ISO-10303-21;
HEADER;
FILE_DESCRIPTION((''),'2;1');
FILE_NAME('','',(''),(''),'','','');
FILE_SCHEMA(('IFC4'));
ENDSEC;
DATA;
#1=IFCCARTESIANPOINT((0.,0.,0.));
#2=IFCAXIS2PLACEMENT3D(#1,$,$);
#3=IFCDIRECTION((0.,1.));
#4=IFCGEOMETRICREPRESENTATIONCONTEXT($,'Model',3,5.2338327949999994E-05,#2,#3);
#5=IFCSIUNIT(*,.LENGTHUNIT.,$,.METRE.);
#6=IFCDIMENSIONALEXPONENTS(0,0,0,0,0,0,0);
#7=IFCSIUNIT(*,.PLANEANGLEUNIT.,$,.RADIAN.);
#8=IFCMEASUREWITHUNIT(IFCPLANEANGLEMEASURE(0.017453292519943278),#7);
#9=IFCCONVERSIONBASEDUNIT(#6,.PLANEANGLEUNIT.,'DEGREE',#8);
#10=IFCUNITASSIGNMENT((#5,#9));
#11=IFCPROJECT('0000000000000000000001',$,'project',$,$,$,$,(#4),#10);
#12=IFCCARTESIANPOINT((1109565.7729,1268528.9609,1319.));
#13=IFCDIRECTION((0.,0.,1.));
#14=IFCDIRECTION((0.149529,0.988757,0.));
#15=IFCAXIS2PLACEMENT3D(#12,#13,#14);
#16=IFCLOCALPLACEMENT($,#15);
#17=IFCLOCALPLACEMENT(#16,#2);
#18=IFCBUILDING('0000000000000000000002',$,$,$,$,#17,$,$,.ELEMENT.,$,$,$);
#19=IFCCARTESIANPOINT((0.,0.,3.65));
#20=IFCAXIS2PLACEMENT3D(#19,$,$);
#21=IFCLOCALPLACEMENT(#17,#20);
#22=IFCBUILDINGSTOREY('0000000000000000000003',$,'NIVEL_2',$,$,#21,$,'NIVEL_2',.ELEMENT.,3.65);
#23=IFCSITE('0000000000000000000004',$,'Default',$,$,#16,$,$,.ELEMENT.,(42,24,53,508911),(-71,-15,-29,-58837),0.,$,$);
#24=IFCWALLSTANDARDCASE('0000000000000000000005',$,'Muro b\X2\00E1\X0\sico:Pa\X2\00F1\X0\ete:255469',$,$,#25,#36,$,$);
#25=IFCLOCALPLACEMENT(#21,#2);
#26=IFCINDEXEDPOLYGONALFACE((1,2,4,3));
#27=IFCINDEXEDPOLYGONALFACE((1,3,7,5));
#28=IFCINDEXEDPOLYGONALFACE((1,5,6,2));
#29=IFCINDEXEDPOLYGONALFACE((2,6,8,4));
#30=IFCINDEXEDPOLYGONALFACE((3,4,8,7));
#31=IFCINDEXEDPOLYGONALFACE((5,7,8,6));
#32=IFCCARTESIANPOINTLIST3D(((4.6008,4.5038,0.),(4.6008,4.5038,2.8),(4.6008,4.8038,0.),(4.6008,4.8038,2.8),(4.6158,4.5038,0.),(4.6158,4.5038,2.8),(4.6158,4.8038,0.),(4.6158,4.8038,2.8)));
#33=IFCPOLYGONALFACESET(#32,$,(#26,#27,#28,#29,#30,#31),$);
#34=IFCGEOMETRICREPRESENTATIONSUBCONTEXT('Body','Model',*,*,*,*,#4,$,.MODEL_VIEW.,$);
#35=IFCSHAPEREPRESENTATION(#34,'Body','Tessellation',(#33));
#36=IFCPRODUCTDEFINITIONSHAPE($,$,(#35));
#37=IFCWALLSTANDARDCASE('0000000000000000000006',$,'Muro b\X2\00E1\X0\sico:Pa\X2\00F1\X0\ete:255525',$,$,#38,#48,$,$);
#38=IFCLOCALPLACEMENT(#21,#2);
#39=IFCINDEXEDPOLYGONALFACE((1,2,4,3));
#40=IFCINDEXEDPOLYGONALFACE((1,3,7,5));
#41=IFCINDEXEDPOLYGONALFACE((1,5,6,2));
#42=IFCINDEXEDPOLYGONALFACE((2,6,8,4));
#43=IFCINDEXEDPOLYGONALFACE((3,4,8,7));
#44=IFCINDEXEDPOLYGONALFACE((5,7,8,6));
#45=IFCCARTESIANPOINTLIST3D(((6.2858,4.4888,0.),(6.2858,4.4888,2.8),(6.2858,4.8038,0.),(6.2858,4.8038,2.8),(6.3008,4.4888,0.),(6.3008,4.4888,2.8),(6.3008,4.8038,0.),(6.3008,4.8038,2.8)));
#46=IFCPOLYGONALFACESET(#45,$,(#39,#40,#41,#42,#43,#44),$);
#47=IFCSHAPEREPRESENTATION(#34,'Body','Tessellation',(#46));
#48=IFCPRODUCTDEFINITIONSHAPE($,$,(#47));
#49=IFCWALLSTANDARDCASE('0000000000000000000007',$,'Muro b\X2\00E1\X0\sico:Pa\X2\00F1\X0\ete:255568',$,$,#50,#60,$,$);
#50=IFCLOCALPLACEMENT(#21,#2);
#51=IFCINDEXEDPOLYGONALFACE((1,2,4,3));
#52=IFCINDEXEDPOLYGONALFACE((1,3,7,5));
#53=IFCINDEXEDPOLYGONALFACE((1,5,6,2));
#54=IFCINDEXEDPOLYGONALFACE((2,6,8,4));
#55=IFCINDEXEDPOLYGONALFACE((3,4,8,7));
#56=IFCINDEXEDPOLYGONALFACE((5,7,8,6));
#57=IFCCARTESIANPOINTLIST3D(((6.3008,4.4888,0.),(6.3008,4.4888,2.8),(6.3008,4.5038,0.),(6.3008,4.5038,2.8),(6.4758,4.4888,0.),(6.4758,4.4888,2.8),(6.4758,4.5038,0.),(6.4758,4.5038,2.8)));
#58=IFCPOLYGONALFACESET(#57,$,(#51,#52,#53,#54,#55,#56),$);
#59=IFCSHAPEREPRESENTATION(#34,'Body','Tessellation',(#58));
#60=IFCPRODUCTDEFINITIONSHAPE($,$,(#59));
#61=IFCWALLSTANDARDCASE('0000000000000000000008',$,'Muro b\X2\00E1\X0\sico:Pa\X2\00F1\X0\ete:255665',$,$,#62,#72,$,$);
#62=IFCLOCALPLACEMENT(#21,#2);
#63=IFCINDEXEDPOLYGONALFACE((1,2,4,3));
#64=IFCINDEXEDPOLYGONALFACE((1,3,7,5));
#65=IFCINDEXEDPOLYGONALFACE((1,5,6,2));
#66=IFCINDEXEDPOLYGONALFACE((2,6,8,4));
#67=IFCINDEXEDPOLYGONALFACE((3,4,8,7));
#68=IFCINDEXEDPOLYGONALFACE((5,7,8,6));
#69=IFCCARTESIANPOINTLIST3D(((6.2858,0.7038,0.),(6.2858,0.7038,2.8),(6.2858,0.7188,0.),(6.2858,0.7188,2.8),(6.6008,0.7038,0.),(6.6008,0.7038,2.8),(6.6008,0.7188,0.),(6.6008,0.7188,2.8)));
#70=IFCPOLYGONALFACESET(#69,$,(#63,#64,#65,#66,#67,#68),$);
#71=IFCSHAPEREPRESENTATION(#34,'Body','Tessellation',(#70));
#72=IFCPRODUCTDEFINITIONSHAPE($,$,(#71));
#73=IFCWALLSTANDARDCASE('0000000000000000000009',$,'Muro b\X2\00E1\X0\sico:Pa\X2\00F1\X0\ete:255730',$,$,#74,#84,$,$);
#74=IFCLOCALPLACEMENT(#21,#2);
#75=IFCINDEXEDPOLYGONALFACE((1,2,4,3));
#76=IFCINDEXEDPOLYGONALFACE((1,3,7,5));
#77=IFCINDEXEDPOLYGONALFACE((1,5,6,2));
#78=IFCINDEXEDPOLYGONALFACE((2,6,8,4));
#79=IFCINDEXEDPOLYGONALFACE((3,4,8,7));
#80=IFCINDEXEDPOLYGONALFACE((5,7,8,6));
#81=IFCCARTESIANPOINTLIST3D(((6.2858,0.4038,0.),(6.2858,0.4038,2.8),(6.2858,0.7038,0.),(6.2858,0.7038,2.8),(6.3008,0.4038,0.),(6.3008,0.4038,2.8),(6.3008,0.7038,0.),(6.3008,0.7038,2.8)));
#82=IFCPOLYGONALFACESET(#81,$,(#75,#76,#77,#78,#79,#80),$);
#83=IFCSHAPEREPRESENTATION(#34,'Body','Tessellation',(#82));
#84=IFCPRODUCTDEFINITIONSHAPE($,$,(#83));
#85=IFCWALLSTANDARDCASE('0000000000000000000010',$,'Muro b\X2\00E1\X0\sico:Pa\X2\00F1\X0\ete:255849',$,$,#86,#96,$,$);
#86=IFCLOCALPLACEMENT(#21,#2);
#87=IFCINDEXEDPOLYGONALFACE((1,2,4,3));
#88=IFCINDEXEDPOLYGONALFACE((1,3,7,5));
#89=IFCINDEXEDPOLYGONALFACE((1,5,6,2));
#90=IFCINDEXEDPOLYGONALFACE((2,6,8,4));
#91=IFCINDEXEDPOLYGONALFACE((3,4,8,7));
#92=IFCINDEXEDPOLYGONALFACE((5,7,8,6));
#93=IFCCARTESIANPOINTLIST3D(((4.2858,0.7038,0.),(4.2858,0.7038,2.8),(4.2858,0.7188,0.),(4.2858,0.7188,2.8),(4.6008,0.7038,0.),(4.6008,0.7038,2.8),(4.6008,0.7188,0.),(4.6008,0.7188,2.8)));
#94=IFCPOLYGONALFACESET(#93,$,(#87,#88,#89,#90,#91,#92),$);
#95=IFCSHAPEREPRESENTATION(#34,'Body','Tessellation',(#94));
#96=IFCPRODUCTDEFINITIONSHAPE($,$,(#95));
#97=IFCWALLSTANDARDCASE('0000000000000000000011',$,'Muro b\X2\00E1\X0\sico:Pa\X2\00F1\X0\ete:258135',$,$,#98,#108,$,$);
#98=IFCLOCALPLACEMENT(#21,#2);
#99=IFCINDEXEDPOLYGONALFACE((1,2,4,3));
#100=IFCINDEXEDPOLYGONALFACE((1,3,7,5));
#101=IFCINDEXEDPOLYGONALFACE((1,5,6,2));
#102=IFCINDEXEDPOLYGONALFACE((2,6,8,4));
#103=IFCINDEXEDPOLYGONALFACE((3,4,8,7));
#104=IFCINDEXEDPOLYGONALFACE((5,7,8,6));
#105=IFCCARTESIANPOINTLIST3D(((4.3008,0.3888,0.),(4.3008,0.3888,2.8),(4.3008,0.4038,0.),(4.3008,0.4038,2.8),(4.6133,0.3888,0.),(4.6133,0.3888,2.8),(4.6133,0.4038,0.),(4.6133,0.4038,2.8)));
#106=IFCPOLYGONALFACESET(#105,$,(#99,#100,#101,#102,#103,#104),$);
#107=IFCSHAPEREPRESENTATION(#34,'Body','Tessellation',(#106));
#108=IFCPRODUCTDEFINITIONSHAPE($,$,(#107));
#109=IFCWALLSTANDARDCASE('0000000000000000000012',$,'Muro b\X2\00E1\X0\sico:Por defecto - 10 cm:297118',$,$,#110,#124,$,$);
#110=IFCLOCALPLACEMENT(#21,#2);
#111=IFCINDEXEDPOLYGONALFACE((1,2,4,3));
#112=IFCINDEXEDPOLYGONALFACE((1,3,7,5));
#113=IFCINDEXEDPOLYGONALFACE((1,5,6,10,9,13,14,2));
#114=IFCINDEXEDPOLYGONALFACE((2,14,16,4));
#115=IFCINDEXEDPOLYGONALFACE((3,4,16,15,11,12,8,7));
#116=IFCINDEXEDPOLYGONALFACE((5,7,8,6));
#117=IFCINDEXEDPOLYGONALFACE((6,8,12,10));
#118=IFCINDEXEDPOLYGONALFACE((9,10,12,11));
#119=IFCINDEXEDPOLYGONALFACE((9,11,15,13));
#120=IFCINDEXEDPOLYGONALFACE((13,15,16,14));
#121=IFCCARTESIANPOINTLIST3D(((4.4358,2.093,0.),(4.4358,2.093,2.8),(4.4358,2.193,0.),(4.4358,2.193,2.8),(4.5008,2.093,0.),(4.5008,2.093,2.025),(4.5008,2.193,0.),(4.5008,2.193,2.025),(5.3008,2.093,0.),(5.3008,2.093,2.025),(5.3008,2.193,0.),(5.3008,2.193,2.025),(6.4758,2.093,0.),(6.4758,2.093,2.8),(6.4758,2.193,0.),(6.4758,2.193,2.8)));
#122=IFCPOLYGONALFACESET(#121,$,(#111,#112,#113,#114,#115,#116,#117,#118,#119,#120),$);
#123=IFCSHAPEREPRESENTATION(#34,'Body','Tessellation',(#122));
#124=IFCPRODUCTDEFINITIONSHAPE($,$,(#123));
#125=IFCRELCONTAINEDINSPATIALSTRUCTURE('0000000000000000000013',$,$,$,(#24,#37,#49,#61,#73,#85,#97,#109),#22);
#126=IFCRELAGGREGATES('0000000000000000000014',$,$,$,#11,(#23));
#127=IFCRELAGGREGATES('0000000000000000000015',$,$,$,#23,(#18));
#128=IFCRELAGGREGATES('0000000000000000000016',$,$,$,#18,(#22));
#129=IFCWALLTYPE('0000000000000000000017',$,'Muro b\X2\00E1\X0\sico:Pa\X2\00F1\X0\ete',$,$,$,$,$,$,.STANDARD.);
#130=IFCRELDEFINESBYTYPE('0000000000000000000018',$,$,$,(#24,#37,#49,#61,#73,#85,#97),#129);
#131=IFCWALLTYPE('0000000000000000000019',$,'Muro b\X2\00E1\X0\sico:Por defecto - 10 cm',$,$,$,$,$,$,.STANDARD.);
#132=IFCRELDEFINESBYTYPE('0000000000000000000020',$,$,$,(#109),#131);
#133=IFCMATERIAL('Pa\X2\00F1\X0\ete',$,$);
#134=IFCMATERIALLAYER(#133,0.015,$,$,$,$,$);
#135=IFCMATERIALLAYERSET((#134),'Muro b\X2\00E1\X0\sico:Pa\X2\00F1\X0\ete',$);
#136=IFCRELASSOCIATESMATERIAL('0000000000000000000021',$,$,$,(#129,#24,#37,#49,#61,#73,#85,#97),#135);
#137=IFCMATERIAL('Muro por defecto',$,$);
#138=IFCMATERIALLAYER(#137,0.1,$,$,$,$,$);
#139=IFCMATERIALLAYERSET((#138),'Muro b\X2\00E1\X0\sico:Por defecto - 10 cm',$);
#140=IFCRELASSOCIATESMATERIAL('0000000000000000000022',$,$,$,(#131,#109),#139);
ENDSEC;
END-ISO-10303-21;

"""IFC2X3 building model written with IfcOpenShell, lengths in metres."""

from ifc_helpers import new_model, entity, si_unit, converted_unit, direction, frame, frame_2d, origin, place, context, subcontext, project, spatial, rectangle, extrude, material, layer, layer_set, layer_usage, type_object, element, save


model = new_model("IFC2X3")

# Units and contexts
model_context = context("Model", 3, precision=5.2338327949999994e-05, world=origin(), true_north=direction((0.0, 1.0)))
body_context = subcontext(model_context, "Body", "Model", "MODEL_VIEW")
ifc_project = project(units=[si_unit("LENGTHUNIT", "METRE"), converted_unit("PLANEANGLEUNIT", "DEGREE", entity("IfcPlaneAngleMeasure", 0.017453292519943278), si_unit("PLANEANGLEUNIT", "RADIAN"), dimensions=[0, 0, 0, 0, 0, 0, 0])], contexts=[model_context])

# Site, building, storey
site_placement = place(None, frame((1109565.7729, 1268528.9609, 1319.0), z_axis=(0.0, 0.0, 1.0), x_axis=(0.149529, 0.988757, 0.0)))
site = spatial("IfcSite", under=ifc_project, at=site_placement, Name="Default", CompositionType="ELEMENT", RefLatitude=(42, 24, 53, 508911), RefLongitude=(-71, -15, -29, -58837), RefElevation=0.0)
building_placement = place(site_placement, origin())
building = spatial("IfcBuilding", under=site, at=building_placement, CompositionType="ELEMENT")
storey_placement = place(building_placement, frame((0.0, 0.0, 3.65)))
storey = spatial("IfcBuildingStorey", under=building, at=storey_placement, Name="NIVEL_2", LongName="NIVEL_2", CompositionType="ELEMENT", Elevation=3.65)

# Shared definitions
ifc_material_1 = material(Name="Pañete")

# Walls
ifc_layer_1 = layer(ifc_material_1, 0.015)
ifc_layer_set_1 = layer_set([ifc_layer_1], Name="Muro básico:Pañete")
wall_type_1 = type_object("IfcWallType", Name="Muro básico:Pañete", PredefinedType="STANDARD", material=ifc_layer_set_1)
ifc_layer_usage_1 = layer_usage(ifc_layer_set_1, "AXIS2", "POSITIVE", -0.0075)
wall_1_placement = place(storey_placement, frame((4.6083, 4.5038, 0.0), z_axis=(0.0, 0.0, 1.0), x_axis=(0.0, 1.0, 0.0)))
element("IfcWallStandardCase", 1, at=wall_1_placement, inside=storey, type_object=wall_type_1, material=ifc_layer_usage_1, Name="Muro básico:Pañete:255469", context=body_context, shape_type="SweptSolid", body=[
    extrude(rectangle(XDim=0.3, YDim=0.015, at=frame_2d((0.15, 0.0), x_axis=(-1.0, 0.0))), origin(), (0.0, 0.0, 1.0), 2.8),
])
ifc_layer_usage_2 = layer_usage(ifc_layer_set_1, "AXIS2", "POSITIVE", -0.0075)
wall_2_placement = place(storey_placement, frame((6.2933, 4.8038, 0.0), z_axis=(0.0, 0.0, 1.0), x_axis=(0.0, -1.0, 0.0)))
element("IfcWallStandardCase", 2, at=wall_2_placement, inside=storey, type_object=wall_type_1, material=ifc_layer_usage_2, Name="Muro básico:Pañete:255525", context=body_context, shape_type="SweptSolid", body=[
    extrude(rectangle(XDim=0.315, YDim=0.015, at=frame_2d((0.1575, 0.0), x_axis=(-1.0, 0.0))), origin(), (0.0, 0.0, 1.0), 2.8),
])
ifc_layer_usage_3 = layer_usage(ifc_layer_set_1, "AXIS2", "POSITIVE", -0.0075)
wall_3_placement = place(storey_placement, frame((6.3008, 4.4963, 0.0)))
element("IfcWallStandardCase", 3, at=wall_3_placement, inside=storey, type_object=wall_type_1, material=ifc_layer_usage_3, Name="Muro básico:Pañete:255568", context=body_context, shape_type="SweptSolid", body=[
    extrude(rectangle(XDim=0.175, YDim=0.015, at=frame_2d((0.0875, 0.0), x_axis=(-1.0, 0.0))), origin(), (0.0, 0.0, 1.0), 2.8),
])
ifc_layer_usage_4 = layer_usage(ifc_layer_set_1, "AXIS2", "POSITIVE", -0.0075)
wall_4_placement = place(storey_placement, frame((6.6008, 0.7113, 0.0), z_axis=(0.0, 0.0, 1.0), x_axis=(-1.0, 0.0, 0.0)))
element("IfcWallStandardCase", 4, at=wall_4_placement, inside=storey, type_object=wall_type_1, material=ifc_layer_usage_4, Name="Muro básico:Pañete:255665", context=body_context, shape_type="SweptSolid", body=[
    extrude(rectangle(XDim=0.315, YDim=0.015, at=frame_2d((0.1575, 0.0), x_axis=(-1.0, 0.0))), origin(), (0.0, 0.0, 1.0), 2.8),
])
ifc_layer_usage_5 = layer_usage(ifc_layer_set_1, "AXIS2", "POSITIVE", -0.0075)
wall_5_placement = place(storey_placement, frame((6.2933, 0.7038, 0.0), z_axis=(0.0, 0.0, 1.0), x_axis=(0.0, -1.0, 0.0)))
element("IfcWallStandardCase", 5, at=wall_5_placement, inside=storey, type_object=wall_type_1, material=ifc_layer_usage_5, Name="Muro básico:Pañete:255730", context=body_context, shape_type="SweptSolid", body=[
    extrude(rectangle(XDim=0.3, YDim=0.015, at=frame_2d((0.15, 0.0), x_axis=(-1.0, 0.0))), origin(), (0.0, 0.0, 1.0), 2.8),
])
ifc_layer_usage_6 = layer_usage(ifc_layer_set_1, "AXIS2", "POSITIVE", -0.0075)
wall_6_placement = place(storey_placement, frame((4.6008, 0.7113, 0.0), z_axis=(0.0, 0.0, 1.0), x_axis=(-1.0, 0.0, 0.0)))
element("IfcWallStandardCase", 6, at=wall_6_placement, inside=storey, type_object=wall_type_1, material=ifc_layer_usage_6, Name="Muro básico:Pañete:255849", context=body_context, shape_type="SweptSolid", body=[
    extrude(rectangle(XDim=0.315, YDim=0.015, at=frame_2d((0.1575, 0.0), x_axis=(-1.0, 0.0))), origin(), (0.0, 0.0, 1.0), 2.8),
])
ifc_layer_usage_7 = layer_usage(ifc_layer_set_1, "AXIS2", "POSITIVE", -0.0075)
wall_7_placement = place(storey_placement, frame((4.3008, 0.3963, 0.0)))
element("IfcWallStandardCase", 7, at=wall_7_placement, inside=storey, type_object=wall_type_1, material=ifc_layer_usage_7, Name="Muro básico:Pañete:258135", context=body_context, shape_type="SweptSolid", body=[
    extrude(rectangle(XDim=0.3125, YDim=0.015, at=frame_2d((0.1562, 0.0), x_axis=(-1.0, 0.0))), origin(), (0.0, 0.0, 1.0), 2.8),
])

# Wall, opening
ifc_material_2 = material(Name="Muro por defecto")
ifc_layer_2 = layer(ifc_material_2, 0.1)
ifc_layer_set_2 = layer_set([ifc_layer_2], Name="Muro básico:Por defecto - 10 cm")
ifc_layer_usage_8 = layer_usage(ifc_layer_set_2, "AXIS2", "POSITIVE", -0.05)
wall_type_2 = type_object("IfcWallType", Name="Muro básico:Por defecto - 10 cm", PredefinedType="STANDARD", material=ifc_layer_set_2)
wall_8_placement = place(storey_placement, frame((6.4758, 2.143, 0.0), z_axis=(0.0, 0.0, 1.0), x_axis=(-1.0, 0.0, 0.0)))
wall_8 = element("IfcWallStandardCase", 8, at=wall_8_placement, inside=storey, type_object=wall_type_2, material=ifc_layer_usage_8, Name="Muro básico:Por defecto - 10 cm:297118", context=body_context, shape_type="SweptSolid", body=[
    extrude(rectangle(XDim=2.04, YDim=0.1, at=frame_2d((1.02, 0.0), x_axis=(-1.0, 0.0))), origin(), (0.0, 0.0, 1.0), 2.8),
])
opening_1_placement = place(wall_8_placement, frame((1.975, 0.05, 0.0)))
element("IfcOpeningElement", 9, at=opening_1_placement, cuts=wall_8, ObjectType="Opening", context=body_context, shape_type="SweptSolid", body=[
    extrude(rectangle(XDim=2.025, YDim=0.8, at=frame_2d((1.0125, 0.4), x_axis=(1.0, 0.0))), frame((0.0, 0.0, 0.0), z_axis=(0.0, -1.0, 0.0), x_axis=(0.0, 0.0, 1.0)), (0.0, 0.0, 1.0), 0.1),
])

save(model, "model.ifc")
